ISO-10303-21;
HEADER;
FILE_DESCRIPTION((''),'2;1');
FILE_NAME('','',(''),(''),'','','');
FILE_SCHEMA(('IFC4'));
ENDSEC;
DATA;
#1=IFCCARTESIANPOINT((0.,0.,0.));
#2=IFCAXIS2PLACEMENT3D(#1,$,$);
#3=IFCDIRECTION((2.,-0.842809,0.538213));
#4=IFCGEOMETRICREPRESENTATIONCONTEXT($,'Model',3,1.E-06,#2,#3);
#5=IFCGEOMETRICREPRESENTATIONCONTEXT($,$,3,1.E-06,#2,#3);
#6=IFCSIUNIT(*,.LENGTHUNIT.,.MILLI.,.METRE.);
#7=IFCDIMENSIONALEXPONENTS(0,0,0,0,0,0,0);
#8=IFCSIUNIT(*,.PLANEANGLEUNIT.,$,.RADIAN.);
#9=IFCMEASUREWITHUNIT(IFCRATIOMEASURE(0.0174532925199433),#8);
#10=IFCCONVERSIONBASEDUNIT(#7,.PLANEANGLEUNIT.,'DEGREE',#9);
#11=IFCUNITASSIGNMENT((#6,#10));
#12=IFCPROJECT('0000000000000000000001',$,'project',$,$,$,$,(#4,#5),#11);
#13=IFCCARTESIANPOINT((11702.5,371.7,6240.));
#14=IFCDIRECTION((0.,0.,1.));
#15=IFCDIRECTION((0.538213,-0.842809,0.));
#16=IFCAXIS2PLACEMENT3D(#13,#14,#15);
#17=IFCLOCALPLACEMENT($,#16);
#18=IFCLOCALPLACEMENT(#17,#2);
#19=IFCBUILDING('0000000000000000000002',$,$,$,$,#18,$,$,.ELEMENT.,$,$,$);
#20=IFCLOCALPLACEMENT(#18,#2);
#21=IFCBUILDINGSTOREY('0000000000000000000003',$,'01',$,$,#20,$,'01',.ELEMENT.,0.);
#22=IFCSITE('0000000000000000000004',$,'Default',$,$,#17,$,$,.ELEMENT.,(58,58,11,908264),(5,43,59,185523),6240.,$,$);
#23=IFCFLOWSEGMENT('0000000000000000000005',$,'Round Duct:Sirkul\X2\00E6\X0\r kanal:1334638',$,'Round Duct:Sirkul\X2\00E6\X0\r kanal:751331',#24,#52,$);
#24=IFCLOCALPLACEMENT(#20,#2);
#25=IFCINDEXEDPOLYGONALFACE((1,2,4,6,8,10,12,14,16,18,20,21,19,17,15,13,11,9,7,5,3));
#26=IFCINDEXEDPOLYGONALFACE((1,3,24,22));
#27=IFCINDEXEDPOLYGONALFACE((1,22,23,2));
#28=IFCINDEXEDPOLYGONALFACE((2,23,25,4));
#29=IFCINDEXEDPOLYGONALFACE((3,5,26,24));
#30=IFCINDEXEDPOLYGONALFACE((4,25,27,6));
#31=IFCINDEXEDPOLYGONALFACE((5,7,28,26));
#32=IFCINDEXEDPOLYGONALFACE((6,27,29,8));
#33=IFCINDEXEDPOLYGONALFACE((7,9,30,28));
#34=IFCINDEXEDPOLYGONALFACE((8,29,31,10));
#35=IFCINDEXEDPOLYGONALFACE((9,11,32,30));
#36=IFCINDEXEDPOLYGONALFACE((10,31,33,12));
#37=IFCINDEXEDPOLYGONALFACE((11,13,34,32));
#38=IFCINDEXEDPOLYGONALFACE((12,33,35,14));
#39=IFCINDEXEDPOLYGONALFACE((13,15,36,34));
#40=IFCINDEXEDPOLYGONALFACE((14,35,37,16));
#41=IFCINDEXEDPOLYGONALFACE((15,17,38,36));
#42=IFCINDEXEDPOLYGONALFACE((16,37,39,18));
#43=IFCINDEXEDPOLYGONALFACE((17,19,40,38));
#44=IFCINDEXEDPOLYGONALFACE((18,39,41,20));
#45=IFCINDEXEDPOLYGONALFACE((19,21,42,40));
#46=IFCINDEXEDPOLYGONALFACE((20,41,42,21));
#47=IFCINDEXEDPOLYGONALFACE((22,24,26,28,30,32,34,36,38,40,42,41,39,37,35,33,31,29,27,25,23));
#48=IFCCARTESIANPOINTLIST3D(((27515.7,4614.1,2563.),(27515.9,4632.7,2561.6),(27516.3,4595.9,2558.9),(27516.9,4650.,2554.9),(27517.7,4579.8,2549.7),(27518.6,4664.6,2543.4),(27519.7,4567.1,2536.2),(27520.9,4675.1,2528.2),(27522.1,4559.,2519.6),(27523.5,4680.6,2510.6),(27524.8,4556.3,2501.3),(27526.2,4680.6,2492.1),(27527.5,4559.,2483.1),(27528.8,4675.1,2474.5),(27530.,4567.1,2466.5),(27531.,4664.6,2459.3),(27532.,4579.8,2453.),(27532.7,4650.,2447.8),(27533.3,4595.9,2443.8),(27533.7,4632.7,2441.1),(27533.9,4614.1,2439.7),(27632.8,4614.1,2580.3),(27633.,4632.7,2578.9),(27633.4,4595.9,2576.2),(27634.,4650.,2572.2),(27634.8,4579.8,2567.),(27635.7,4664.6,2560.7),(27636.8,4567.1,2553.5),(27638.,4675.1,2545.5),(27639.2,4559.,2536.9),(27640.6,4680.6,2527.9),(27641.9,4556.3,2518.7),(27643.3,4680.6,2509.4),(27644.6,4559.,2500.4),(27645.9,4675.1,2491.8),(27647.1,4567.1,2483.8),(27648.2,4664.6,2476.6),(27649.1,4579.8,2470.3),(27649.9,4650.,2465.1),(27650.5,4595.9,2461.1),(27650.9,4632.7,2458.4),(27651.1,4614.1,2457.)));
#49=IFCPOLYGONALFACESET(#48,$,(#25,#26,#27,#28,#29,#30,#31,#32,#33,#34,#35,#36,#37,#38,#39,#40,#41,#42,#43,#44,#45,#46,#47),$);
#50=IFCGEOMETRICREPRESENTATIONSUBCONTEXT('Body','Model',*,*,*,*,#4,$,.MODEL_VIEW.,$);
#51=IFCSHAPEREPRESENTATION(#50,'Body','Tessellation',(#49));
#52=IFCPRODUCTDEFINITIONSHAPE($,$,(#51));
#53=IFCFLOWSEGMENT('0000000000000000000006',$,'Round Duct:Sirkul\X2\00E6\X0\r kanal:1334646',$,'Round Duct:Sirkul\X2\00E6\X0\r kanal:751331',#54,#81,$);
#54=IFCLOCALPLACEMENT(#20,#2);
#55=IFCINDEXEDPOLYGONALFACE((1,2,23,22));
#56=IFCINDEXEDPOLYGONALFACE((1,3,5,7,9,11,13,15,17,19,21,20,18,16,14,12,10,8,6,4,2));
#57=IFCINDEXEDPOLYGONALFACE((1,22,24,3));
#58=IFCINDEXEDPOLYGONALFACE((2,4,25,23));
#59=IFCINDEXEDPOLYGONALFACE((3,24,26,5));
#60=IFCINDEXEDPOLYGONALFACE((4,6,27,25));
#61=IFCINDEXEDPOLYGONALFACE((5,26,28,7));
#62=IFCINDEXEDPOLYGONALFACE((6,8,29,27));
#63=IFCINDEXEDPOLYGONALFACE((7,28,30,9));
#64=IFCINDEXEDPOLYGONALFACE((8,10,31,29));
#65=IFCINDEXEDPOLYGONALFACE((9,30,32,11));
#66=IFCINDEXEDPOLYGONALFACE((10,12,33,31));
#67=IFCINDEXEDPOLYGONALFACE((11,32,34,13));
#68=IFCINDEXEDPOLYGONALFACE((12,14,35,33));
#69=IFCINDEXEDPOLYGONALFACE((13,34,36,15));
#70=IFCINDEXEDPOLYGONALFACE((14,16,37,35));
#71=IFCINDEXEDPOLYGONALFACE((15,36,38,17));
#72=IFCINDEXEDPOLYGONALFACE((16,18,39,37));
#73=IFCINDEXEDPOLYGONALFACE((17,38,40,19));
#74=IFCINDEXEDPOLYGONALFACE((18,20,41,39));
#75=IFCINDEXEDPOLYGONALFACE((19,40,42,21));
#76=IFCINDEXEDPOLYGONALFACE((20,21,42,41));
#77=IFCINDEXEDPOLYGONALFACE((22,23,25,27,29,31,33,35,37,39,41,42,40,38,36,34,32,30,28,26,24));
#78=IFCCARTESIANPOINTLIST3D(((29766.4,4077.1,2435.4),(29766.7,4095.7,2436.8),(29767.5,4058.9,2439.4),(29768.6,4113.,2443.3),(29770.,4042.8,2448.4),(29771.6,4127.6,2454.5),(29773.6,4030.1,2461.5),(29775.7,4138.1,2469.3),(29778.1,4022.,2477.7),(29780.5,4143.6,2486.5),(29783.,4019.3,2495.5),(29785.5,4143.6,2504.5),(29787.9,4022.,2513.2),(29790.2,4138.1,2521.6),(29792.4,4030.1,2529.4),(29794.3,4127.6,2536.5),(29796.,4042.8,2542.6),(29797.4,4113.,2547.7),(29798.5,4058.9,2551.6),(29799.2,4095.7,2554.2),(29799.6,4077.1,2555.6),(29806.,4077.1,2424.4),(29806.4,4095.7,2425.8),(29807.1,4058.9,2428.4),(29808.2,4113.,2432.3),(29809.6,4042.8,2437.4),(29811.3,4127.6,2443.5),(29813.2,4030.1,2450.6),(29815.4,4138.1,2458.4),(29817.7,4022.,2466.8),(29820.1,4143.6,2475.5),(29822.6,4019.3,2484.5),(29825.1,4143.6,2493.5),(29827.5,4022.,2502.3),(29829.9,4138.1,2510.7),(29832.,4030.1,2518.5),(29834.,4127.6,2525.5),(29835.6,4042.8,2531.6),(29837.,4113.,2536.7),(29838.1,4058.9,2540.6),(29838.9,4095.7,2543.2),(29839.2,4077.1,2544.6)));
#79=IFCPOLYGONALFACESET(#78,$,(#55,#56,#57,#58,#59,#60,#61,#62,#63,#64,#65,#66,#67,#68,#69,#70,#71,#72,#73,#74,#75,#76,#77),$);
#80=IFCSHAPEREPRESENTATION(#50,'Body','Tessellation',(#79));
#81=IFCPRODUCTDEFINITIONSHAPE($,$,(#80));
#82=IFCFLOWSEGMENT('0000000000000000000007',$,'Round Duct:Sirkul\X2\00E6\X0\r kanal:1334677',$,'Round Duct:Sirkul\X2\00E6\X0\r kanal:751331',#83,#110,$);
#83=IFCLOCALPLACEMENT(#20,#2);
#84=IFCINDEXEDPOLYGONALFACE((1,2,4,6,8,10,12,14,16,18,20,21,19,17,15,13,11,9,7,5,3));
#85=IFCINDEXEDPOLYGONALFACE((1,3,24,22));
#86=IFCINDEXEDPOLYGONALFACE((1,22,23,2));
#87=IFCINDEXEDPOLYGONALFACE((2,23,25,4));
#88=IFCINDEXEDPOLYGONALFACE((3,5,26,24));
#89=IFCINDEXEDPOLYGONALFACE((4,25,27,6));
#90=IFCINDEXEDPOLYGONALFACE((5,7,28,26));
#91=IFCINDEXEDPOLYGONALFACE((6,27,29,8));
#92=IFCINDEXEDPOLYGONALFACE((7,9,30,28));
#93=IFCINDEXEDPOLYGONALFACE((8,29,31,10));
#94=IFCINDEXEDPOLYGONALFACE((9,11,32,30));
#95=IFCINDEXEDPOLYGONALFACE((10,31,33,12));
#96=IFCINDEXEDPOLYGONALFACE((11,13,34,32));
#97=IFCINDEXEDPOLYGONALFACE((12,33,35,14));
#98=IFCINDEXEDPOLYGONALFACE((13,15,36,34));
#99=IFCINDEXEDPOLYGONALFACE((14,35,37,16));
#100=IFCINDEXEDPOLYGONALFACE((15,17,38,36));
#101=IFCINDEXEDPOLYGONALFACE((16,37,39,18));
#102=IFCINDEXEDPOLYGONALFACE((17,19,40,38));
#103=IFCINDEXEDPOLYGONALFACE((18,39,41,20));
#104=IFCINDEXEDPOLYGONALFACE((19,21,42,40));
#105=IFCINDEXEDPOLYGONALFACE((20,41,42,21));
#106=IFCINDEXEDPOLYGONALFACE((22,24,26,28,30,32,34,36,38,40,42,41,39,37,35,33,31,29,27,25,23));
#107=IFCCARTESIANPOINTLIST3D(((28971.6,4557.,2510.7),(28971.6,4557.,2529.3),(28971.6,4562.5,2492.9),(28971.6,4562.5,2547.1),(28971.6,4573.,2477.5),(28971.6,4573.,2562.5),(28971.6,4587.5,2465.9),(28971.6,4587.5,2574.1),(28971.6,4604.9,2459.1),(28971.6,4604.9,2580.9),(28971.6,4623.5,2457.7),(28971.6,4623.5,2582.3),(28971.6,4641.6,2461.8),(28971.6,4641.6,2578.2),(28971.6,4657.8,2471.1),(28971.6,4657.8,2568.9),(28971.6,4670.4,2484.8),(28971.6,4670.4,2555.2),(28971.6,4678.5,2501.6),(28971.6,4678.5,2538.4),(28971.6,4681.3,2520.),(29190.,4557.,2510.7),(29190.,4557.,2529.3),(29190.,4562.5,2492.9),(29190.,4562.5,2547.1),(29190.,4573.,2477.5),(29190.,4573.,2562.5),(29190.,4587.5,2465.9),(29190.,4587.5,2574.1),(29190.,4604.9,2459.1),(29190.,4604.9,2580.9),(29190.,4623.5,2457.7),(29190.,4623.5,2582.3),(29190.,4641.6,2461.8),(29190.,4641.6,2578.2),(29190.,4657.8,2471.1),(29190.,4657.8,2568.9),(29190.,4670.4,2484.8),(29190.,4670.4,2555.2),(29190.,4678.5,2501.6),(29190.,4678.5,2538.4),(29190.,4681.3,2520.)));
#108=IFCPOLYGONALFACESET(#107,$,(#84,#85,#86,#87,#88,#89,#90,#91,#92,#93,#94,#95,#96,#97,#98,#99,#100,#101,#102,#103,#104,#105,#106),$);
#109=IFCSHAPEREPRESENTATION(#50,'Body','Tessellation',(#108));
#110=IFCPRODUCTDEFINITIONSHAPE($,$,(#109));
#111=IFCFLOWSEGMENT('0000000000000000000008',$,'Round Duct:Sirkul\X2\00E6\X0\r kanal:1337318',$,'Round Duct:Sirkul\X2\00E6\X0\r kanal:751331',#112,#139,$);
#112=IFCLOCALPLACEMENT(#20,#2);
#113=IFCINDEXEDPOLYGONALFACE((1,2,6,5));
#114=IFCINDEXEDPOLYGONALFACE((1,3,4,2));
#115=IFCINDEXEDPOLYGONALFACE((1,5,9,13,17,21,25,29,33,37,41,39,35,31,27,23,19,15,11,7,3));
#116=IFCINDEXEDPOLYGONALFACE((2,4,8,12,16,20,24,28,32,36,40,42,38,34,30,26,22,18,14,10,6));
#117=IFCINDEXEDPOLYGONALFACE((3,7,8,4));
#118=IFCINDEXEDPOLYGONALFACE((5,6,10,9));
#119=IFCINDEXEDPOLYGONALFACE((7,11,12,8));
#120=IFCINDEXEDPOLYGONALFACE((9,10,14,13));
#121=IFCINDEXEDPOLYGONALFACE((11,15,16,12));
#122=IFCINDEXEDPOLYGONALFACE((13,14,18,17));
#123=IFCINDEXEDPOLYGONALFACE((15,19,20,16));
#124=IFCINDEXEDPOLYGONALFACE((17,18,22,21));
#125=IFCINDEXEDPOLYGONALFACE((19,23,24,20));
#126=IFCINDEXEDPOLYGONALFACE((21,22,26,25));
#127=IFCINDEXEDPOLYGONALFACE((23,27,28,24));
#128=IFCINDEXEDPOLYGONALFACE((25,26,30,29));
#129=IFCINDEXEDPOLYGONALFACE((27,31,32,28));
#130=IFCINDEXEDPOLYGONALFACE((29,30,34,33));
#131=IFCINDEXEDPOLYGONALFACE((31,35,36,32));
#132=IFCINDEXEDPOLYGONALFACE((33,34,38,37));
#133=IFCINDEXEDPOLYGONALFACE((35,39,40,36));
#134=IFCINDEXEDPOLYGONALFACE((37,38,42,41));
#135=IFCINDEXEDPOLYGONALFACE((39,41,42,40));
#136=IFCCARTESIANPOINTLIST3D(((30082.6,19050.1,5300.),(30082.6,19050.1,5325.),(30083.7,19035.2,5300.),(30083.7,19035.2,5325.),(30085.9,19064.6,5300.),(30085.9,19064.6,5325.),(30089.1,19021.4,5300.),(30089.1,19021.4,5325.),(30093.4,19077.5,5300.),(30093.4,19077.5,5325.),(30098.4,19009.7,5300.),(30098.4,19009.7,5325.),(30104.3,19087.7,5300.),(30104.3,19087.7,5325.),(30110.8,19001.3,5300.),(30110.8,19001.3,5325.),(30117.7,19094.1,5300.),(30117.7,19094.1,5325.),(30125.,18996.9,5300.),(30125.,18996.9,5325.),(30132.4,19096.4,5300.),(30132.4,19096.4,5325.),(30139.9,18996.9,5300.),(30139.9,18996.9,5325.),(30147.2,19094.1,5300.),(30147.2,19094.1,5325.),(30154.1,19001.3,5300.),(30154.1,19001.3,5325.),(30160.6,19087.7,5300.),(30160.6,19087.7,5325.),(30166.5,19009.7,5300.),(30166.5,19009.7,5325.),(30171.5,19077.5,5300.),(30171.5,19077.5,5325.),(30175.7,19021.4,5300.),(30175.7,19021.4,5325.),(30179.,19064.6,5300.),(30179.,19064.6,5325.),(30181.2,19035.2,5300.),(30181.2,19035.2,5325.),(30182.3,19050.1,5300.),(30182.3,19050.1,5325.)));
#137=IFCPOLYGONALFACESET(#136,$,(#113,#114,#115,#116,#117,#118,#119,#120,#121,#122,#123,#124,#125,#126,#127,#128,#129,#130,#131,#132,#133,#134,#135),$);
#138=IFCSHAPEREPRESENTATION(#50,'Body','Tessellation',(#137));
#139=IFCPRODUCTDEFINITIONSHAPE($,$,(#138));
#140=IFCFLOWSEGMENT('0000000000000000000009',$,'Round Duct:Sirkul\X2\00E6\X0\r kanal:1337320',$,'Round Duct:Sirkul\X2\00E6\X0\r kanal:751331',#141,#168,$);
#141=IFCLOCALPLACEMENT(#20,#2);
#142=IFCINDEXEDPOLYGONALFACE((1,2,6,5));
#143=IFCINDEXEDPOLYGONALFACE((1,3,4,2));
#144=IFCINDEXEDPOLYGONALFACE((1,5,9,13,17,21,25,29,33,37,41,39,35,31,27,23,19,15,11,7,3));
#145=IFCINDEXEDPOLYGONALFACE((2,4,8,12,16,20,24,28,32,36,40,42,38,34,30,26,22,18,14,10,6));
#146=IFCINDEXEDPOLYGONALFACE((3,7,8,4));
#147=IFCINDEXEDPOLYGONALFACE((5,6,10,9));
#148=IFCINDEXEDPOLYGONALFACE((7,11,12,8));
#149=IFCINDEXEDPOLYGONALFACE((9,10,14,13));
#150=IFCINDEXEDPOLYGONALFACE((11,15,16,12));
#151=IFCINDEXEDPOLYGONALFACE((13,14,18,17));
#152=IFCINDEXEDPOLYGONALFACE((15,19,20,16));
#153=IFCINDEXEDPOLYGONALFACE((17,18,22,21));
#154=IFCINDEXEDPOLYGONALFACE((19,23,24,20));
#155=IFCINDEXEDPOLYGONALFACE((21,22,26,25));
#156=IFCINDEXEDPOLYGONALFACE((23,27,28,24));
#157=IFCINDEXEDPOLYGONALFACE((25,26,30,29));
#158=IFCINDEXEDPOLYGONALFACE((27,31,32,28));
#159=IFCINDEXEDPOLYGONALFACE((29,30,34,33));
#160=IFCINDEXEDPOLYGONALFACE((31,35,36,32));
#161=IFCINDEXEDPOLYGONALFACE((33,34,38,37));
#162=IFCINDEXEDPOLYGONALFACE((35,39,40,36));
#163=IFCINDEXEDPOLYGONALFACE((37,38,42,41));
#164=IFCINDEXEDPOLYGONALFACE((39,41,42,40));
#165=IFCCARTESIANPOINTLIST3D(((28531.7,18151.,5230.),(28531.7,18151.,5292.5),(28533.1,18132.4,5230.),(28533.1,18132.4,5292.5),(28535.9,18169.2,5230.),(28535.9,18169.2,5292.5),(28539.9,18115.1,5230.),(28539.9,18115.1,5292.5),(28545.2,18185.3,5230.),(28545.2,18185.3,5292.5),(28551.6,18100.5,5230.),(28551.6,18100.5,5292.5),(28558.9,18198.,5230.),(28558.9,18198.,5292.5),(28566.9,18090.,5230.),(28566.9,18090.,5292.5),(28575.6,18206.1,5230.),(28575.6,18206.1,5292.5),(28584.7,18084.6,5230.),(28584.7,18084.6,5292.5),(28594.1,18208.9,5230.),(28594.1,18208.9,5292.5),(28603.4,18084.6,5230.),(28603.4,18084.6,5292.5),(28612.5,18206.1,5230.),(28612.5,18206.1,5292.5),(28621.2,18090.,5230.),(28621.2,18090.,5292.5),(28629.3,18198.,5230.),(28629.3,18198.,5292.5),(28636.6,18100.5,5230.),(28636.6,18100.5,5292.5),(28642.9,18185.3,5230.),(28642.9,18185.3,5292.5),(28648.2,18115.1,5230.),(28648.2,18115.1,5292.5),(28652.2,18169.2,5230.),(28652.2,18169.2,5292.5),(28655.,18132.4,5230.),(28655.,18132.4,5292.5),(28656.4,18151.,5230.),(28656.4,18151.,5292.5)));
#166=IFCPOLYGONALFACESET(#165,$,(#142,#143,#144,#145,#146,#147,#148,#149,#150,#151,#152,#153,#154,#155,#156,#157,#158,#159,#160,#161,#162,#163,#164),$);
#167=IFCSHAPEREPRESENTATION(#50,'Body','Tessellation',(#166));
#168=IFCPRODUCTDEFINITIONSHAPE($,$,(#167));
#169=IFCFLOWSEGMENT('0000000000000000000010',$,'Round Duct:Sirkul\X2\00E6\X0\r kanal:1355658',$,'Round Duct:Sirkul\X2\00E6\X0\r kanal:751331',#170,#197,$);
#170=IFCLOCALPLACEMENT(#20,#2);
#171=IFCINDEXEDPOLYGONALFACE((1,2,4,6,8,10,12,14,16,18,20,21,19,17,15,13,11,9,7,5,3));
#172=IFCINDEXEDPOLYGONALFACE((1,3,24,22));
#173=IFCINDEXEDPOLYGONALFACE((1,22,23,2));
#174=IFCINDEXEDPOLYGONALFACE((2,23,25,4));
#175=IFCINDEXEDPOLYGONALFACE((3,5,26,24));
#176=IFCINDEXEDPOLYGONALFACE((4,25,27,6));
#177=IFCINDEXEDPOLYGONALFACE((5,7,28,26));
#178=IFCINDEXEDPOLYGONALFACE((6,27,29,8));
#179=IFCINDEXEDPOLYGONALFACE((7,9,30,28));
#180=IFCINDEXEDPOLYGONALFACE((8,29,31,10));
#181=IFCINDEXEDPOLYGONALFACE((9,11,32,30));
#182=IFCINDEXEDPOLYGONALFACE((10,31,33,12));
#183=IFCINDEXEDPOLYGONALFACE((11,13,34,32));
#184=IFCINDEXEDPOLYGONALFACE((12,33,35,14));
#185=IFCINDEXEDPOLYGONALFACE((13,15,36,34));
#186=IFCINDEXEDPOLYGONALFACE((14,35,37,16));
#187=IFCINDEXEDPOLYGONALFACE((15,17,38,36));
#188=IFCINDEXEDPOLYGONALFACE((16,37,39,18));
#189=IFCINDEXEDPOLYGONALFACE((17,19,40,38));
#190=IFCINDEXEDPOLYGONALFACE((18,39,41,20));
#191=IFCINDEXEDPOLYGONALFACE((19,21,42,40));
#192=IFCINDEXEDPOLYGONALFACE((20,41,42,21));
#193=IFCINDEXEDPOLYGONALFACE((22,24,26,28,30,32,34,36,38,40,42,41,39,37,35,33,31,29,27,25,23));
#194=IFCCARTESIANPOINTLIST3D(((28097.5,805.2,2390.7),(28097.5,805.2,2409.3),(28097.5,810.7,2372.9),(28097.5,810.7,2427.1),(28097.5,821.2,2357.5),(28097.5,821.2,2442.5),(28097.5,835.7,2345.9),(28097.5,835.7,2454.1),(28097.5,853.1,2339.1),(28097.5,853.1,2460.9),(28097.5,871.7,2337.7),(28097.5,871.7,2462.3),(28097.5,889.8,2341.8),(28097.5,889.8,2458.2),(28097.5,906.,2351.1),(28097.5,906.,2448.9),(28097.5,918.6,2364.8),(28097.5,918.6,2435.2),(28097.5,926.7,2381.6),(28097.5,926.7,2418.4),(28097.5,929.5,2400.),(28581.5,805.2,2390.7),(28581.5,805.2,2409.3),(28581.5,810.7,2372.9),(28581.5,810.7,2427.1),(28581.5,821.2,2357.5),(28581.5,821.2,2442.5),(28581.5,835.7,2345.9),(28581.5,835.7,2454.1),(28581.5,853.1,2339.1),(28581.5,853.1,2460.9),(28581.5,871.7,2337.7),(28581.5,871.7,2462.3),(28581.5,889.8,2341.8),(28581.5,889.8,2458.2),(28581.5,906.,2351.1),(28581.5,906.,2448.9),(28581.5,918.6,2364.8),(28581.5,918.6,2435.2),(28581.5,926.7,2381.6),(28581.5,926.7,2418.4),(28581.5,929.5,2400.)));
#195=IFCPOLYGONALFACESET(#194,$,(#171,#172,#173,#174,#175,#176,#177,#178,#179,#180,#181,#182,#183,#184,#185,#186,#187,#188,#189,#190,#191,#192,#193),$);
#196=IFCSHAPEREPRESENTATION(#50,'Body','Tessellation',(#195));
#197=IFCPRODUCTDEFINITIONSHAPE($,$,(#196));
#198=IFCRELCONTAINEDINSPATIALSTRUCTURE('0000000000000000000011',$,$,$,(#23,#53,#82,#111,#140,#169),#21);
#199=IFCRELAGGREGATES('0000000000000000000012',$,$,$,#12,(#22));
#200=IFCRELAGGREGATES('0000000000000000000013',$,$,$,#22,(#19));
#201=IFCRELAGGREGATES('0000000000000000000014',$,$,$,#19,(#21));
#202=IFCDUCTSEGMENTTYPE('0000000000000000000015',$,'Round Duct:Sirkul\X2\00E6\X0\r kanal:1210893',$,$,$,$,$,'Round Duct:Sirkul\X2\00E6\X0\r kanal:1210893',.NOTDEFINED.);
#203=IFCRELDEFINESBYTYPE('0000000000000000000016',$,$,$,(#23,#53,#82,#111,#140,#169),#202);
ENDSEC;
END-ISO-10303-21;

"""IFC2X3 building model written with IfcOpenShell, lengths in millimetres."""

from ifc_helpers import new_model, entity, si_unit, converted_unit, direction, frame, frame_2d, origin, place, context, subcontext, project, spatial, circle, extrude, type_object, element, save


model = new_model("IFC2X3")

# Units and contexts
model_context = context("Model", 3, precision=1e-06, world=origin(), true_north=direction((2.0, -0.842809, 0.538213)))
context_of_model = context(None, 3, precision=1e-06, world=origin(), true_north=direction((2.0, -0.842809, 0.538213)))
body_context = subcontext(model_context, "Body", "Model", "MODEL_VIEW")
ifc_project = project(units=[si_unit("LENGTHUNIT", "METRE", prefix="MILLI"), converted_unit("PLANEANGLEUNIT", "DEGREE", entity("IfcRatioMeasure", 0.0174532925199433), si_unit("PLANEANGLEUNIT", "RADIAN"), dimensions=[0, 0, 0, 0, 0, 0, 0])], contexts=[model_context, context_of_model])

# Site, building, storey
site_placement = place(None, frame((11702.5, 371.7, 6240.0), z_axis=(0.0, 0.0, 1.0), x_axis=(0.538213, -0.842809, 0.0)))
site = spatial("IfcSite", under=ifc_project, at=site_placement, Name="Default", CompositionType="ELEMENT", RefLatitude=(58, 58, 11, 908264), RefLongitude=(5, 43, 59, 185523), RefElevation=6240.0)
building_placement = place(site_placement, origin())
building = spatial("IfcBuilding", under=site, at=building_placement, CompositionType="ELEMENT")
storey_placement = place(building_placement, origin())
storey = spatial("IfcBuildingStorey", under=building, at=storey_placement, Name="01", LongName="01", CompositionType="ELEMENT", Elevation=0.0)

# Flow segments
duct_segment_type = type_object("IfcDuctSegmentType", Name="Round Duct:Sirkulær kanal:1210893", ElementType="Round Duct:Sirkulær kanal:1210893", PredefinedType="NOTDEFINED")
flow_segment_1_placement = place(storey_placement, origin())
element("IfcFlowSegment", 1, at=flow_segment_1_placement, inside=storey, type_object=duct_segment_type, Name="Round Duct:Sirkulær kanal:1334638", ObjectType="Round Duct:Sirkulær kanal:751331", context=body_context, shape_type="SweptSolid", body=[
    extrude(circle(Radius=62.5, at=frame_2d((0.0, 0.0), x_axis=(1.0, 0.0))), frame((27524.8, 4618.8, 2501.3), z_axis=(0.98925, 0.0, 0.146233), x_axis=(0.0, -1.0, 0.0)), (0.0, 0.0, 1.0), 118.4),
])
flow_segment_2_placement = place(storey_placement, origin())
element("IfcFlowSegment", 2, at=flow_segment_2_placement, inside=storey, type_object=duct_segment_type, Name="Round Duct:Sirkulær kanal:1334646", ObjectType="Round Duct:Sirkulær kanal:751331", context=body_context, shape_type="SweptSolid", body=[
    extrude(circle(Radius=62.5, at=frame_2d((0.0, 0.0), x_axis=(1.0, 0.0))), frame((29822.6, 4081.8, 2484.5), z_axis=(-0.963847, 0.0, 0.266455), x_axis=(0.0, -1.0, 0.0)), (0.0, 0.0, 1.0), 41.1),
])
flow_segment_3_placement = place(storey_placement, origin())
element("IfcFlowSegment", 3, at=flow_segment_3_placement, inside=storey, type_object=duct_segment_type, Name="Round Duct:Sirkulær kanal:1334677", ObjectType="Round Duct:Sirkulær kanal:751331", context=body_context, shape_type="SweptSolid", body=[
    extrude(circle(Radius=62.5, at=frame_2d((0.0, 0.0), x_axis=(1.0, 0.0))), frame((28971.6, 4618.8, 2520.0), z_axis=(1.0, 0.0, 0.0), x_axis=(0.0, 1.0, 0.0)), (0.0, 0.0, 1.0), 218.4),
])
flow_segment_4_placement = place(storey_placement, origin())
element("IfcFlowSegment", 4, at=flow_segment_4_placement, inside=storey, type_object=duct_segment_type, Name="Round Duct:Sirkulær kanal:1337318", ObjectType="Round Duct:Sirkulær kanal:751331", context=body_context, shape_type="SweptSolid", body=[
    extrude(circle(Radius=50.0, at=frame_2d((0.0, 0.0), x_axis=(1.0, 0.0))), frame((30132.4, 19046.4, 5300.0), z_axis=(0.0, 0.0, 1.0), x_axis=(0.0, 1.0, 0.0)), (0.0, 0.0, 1.0), 25.0),
])
flow_segment_5_placement = place(storey_placement, origin())
element("IfcFlowSegment", 5, at=flow_segment_5_placement, inside=storey, type_object=duct_segment_type, Name="Round Duct:Sirkulær kanal:1337320", ObjectType="Round Duct:Sirkulær kanal:751331", context=body_context, shape_type="SweptSolid", body=[
    extrude(circle(Radius=62.5, at=frame_2d((0.0, 0.0), x_axis=(1.0, 0.0))), frame((28594.1, 18146.4, 5230.0), z_axis=(0.0, 0.0, 1.0), x_axis=(0.0, 1.0, 0.0)), (0.0, 0.0, 1.0), 62.5),
])
flow_segment_6_placement = place(storey_placement, origin())
element("IfcFlowSegment", 6, at=flow_segment_6_placement, inside=storey, type_object=duct_segment_type, Name="Round Duct:Sirkulær kanal:1355658", ObjectType="Round Duct:Sirkulær kanal:751331", context=body_context, shape_type="SweptSolid", body=[
    extrude(circle(Radius=62.5, at=frame_2d((0.0, 0.0), x_axis=(1.0, 0.0))), frame((28097.5, 867.0, 2400.0), z_axis=(1.0, 0.0, 0.0), x_axis=(0.0, 1.0, 0.0)), (0.0, 0.0, 1.0), 484.0),
])

save(model, "model.ifc")
